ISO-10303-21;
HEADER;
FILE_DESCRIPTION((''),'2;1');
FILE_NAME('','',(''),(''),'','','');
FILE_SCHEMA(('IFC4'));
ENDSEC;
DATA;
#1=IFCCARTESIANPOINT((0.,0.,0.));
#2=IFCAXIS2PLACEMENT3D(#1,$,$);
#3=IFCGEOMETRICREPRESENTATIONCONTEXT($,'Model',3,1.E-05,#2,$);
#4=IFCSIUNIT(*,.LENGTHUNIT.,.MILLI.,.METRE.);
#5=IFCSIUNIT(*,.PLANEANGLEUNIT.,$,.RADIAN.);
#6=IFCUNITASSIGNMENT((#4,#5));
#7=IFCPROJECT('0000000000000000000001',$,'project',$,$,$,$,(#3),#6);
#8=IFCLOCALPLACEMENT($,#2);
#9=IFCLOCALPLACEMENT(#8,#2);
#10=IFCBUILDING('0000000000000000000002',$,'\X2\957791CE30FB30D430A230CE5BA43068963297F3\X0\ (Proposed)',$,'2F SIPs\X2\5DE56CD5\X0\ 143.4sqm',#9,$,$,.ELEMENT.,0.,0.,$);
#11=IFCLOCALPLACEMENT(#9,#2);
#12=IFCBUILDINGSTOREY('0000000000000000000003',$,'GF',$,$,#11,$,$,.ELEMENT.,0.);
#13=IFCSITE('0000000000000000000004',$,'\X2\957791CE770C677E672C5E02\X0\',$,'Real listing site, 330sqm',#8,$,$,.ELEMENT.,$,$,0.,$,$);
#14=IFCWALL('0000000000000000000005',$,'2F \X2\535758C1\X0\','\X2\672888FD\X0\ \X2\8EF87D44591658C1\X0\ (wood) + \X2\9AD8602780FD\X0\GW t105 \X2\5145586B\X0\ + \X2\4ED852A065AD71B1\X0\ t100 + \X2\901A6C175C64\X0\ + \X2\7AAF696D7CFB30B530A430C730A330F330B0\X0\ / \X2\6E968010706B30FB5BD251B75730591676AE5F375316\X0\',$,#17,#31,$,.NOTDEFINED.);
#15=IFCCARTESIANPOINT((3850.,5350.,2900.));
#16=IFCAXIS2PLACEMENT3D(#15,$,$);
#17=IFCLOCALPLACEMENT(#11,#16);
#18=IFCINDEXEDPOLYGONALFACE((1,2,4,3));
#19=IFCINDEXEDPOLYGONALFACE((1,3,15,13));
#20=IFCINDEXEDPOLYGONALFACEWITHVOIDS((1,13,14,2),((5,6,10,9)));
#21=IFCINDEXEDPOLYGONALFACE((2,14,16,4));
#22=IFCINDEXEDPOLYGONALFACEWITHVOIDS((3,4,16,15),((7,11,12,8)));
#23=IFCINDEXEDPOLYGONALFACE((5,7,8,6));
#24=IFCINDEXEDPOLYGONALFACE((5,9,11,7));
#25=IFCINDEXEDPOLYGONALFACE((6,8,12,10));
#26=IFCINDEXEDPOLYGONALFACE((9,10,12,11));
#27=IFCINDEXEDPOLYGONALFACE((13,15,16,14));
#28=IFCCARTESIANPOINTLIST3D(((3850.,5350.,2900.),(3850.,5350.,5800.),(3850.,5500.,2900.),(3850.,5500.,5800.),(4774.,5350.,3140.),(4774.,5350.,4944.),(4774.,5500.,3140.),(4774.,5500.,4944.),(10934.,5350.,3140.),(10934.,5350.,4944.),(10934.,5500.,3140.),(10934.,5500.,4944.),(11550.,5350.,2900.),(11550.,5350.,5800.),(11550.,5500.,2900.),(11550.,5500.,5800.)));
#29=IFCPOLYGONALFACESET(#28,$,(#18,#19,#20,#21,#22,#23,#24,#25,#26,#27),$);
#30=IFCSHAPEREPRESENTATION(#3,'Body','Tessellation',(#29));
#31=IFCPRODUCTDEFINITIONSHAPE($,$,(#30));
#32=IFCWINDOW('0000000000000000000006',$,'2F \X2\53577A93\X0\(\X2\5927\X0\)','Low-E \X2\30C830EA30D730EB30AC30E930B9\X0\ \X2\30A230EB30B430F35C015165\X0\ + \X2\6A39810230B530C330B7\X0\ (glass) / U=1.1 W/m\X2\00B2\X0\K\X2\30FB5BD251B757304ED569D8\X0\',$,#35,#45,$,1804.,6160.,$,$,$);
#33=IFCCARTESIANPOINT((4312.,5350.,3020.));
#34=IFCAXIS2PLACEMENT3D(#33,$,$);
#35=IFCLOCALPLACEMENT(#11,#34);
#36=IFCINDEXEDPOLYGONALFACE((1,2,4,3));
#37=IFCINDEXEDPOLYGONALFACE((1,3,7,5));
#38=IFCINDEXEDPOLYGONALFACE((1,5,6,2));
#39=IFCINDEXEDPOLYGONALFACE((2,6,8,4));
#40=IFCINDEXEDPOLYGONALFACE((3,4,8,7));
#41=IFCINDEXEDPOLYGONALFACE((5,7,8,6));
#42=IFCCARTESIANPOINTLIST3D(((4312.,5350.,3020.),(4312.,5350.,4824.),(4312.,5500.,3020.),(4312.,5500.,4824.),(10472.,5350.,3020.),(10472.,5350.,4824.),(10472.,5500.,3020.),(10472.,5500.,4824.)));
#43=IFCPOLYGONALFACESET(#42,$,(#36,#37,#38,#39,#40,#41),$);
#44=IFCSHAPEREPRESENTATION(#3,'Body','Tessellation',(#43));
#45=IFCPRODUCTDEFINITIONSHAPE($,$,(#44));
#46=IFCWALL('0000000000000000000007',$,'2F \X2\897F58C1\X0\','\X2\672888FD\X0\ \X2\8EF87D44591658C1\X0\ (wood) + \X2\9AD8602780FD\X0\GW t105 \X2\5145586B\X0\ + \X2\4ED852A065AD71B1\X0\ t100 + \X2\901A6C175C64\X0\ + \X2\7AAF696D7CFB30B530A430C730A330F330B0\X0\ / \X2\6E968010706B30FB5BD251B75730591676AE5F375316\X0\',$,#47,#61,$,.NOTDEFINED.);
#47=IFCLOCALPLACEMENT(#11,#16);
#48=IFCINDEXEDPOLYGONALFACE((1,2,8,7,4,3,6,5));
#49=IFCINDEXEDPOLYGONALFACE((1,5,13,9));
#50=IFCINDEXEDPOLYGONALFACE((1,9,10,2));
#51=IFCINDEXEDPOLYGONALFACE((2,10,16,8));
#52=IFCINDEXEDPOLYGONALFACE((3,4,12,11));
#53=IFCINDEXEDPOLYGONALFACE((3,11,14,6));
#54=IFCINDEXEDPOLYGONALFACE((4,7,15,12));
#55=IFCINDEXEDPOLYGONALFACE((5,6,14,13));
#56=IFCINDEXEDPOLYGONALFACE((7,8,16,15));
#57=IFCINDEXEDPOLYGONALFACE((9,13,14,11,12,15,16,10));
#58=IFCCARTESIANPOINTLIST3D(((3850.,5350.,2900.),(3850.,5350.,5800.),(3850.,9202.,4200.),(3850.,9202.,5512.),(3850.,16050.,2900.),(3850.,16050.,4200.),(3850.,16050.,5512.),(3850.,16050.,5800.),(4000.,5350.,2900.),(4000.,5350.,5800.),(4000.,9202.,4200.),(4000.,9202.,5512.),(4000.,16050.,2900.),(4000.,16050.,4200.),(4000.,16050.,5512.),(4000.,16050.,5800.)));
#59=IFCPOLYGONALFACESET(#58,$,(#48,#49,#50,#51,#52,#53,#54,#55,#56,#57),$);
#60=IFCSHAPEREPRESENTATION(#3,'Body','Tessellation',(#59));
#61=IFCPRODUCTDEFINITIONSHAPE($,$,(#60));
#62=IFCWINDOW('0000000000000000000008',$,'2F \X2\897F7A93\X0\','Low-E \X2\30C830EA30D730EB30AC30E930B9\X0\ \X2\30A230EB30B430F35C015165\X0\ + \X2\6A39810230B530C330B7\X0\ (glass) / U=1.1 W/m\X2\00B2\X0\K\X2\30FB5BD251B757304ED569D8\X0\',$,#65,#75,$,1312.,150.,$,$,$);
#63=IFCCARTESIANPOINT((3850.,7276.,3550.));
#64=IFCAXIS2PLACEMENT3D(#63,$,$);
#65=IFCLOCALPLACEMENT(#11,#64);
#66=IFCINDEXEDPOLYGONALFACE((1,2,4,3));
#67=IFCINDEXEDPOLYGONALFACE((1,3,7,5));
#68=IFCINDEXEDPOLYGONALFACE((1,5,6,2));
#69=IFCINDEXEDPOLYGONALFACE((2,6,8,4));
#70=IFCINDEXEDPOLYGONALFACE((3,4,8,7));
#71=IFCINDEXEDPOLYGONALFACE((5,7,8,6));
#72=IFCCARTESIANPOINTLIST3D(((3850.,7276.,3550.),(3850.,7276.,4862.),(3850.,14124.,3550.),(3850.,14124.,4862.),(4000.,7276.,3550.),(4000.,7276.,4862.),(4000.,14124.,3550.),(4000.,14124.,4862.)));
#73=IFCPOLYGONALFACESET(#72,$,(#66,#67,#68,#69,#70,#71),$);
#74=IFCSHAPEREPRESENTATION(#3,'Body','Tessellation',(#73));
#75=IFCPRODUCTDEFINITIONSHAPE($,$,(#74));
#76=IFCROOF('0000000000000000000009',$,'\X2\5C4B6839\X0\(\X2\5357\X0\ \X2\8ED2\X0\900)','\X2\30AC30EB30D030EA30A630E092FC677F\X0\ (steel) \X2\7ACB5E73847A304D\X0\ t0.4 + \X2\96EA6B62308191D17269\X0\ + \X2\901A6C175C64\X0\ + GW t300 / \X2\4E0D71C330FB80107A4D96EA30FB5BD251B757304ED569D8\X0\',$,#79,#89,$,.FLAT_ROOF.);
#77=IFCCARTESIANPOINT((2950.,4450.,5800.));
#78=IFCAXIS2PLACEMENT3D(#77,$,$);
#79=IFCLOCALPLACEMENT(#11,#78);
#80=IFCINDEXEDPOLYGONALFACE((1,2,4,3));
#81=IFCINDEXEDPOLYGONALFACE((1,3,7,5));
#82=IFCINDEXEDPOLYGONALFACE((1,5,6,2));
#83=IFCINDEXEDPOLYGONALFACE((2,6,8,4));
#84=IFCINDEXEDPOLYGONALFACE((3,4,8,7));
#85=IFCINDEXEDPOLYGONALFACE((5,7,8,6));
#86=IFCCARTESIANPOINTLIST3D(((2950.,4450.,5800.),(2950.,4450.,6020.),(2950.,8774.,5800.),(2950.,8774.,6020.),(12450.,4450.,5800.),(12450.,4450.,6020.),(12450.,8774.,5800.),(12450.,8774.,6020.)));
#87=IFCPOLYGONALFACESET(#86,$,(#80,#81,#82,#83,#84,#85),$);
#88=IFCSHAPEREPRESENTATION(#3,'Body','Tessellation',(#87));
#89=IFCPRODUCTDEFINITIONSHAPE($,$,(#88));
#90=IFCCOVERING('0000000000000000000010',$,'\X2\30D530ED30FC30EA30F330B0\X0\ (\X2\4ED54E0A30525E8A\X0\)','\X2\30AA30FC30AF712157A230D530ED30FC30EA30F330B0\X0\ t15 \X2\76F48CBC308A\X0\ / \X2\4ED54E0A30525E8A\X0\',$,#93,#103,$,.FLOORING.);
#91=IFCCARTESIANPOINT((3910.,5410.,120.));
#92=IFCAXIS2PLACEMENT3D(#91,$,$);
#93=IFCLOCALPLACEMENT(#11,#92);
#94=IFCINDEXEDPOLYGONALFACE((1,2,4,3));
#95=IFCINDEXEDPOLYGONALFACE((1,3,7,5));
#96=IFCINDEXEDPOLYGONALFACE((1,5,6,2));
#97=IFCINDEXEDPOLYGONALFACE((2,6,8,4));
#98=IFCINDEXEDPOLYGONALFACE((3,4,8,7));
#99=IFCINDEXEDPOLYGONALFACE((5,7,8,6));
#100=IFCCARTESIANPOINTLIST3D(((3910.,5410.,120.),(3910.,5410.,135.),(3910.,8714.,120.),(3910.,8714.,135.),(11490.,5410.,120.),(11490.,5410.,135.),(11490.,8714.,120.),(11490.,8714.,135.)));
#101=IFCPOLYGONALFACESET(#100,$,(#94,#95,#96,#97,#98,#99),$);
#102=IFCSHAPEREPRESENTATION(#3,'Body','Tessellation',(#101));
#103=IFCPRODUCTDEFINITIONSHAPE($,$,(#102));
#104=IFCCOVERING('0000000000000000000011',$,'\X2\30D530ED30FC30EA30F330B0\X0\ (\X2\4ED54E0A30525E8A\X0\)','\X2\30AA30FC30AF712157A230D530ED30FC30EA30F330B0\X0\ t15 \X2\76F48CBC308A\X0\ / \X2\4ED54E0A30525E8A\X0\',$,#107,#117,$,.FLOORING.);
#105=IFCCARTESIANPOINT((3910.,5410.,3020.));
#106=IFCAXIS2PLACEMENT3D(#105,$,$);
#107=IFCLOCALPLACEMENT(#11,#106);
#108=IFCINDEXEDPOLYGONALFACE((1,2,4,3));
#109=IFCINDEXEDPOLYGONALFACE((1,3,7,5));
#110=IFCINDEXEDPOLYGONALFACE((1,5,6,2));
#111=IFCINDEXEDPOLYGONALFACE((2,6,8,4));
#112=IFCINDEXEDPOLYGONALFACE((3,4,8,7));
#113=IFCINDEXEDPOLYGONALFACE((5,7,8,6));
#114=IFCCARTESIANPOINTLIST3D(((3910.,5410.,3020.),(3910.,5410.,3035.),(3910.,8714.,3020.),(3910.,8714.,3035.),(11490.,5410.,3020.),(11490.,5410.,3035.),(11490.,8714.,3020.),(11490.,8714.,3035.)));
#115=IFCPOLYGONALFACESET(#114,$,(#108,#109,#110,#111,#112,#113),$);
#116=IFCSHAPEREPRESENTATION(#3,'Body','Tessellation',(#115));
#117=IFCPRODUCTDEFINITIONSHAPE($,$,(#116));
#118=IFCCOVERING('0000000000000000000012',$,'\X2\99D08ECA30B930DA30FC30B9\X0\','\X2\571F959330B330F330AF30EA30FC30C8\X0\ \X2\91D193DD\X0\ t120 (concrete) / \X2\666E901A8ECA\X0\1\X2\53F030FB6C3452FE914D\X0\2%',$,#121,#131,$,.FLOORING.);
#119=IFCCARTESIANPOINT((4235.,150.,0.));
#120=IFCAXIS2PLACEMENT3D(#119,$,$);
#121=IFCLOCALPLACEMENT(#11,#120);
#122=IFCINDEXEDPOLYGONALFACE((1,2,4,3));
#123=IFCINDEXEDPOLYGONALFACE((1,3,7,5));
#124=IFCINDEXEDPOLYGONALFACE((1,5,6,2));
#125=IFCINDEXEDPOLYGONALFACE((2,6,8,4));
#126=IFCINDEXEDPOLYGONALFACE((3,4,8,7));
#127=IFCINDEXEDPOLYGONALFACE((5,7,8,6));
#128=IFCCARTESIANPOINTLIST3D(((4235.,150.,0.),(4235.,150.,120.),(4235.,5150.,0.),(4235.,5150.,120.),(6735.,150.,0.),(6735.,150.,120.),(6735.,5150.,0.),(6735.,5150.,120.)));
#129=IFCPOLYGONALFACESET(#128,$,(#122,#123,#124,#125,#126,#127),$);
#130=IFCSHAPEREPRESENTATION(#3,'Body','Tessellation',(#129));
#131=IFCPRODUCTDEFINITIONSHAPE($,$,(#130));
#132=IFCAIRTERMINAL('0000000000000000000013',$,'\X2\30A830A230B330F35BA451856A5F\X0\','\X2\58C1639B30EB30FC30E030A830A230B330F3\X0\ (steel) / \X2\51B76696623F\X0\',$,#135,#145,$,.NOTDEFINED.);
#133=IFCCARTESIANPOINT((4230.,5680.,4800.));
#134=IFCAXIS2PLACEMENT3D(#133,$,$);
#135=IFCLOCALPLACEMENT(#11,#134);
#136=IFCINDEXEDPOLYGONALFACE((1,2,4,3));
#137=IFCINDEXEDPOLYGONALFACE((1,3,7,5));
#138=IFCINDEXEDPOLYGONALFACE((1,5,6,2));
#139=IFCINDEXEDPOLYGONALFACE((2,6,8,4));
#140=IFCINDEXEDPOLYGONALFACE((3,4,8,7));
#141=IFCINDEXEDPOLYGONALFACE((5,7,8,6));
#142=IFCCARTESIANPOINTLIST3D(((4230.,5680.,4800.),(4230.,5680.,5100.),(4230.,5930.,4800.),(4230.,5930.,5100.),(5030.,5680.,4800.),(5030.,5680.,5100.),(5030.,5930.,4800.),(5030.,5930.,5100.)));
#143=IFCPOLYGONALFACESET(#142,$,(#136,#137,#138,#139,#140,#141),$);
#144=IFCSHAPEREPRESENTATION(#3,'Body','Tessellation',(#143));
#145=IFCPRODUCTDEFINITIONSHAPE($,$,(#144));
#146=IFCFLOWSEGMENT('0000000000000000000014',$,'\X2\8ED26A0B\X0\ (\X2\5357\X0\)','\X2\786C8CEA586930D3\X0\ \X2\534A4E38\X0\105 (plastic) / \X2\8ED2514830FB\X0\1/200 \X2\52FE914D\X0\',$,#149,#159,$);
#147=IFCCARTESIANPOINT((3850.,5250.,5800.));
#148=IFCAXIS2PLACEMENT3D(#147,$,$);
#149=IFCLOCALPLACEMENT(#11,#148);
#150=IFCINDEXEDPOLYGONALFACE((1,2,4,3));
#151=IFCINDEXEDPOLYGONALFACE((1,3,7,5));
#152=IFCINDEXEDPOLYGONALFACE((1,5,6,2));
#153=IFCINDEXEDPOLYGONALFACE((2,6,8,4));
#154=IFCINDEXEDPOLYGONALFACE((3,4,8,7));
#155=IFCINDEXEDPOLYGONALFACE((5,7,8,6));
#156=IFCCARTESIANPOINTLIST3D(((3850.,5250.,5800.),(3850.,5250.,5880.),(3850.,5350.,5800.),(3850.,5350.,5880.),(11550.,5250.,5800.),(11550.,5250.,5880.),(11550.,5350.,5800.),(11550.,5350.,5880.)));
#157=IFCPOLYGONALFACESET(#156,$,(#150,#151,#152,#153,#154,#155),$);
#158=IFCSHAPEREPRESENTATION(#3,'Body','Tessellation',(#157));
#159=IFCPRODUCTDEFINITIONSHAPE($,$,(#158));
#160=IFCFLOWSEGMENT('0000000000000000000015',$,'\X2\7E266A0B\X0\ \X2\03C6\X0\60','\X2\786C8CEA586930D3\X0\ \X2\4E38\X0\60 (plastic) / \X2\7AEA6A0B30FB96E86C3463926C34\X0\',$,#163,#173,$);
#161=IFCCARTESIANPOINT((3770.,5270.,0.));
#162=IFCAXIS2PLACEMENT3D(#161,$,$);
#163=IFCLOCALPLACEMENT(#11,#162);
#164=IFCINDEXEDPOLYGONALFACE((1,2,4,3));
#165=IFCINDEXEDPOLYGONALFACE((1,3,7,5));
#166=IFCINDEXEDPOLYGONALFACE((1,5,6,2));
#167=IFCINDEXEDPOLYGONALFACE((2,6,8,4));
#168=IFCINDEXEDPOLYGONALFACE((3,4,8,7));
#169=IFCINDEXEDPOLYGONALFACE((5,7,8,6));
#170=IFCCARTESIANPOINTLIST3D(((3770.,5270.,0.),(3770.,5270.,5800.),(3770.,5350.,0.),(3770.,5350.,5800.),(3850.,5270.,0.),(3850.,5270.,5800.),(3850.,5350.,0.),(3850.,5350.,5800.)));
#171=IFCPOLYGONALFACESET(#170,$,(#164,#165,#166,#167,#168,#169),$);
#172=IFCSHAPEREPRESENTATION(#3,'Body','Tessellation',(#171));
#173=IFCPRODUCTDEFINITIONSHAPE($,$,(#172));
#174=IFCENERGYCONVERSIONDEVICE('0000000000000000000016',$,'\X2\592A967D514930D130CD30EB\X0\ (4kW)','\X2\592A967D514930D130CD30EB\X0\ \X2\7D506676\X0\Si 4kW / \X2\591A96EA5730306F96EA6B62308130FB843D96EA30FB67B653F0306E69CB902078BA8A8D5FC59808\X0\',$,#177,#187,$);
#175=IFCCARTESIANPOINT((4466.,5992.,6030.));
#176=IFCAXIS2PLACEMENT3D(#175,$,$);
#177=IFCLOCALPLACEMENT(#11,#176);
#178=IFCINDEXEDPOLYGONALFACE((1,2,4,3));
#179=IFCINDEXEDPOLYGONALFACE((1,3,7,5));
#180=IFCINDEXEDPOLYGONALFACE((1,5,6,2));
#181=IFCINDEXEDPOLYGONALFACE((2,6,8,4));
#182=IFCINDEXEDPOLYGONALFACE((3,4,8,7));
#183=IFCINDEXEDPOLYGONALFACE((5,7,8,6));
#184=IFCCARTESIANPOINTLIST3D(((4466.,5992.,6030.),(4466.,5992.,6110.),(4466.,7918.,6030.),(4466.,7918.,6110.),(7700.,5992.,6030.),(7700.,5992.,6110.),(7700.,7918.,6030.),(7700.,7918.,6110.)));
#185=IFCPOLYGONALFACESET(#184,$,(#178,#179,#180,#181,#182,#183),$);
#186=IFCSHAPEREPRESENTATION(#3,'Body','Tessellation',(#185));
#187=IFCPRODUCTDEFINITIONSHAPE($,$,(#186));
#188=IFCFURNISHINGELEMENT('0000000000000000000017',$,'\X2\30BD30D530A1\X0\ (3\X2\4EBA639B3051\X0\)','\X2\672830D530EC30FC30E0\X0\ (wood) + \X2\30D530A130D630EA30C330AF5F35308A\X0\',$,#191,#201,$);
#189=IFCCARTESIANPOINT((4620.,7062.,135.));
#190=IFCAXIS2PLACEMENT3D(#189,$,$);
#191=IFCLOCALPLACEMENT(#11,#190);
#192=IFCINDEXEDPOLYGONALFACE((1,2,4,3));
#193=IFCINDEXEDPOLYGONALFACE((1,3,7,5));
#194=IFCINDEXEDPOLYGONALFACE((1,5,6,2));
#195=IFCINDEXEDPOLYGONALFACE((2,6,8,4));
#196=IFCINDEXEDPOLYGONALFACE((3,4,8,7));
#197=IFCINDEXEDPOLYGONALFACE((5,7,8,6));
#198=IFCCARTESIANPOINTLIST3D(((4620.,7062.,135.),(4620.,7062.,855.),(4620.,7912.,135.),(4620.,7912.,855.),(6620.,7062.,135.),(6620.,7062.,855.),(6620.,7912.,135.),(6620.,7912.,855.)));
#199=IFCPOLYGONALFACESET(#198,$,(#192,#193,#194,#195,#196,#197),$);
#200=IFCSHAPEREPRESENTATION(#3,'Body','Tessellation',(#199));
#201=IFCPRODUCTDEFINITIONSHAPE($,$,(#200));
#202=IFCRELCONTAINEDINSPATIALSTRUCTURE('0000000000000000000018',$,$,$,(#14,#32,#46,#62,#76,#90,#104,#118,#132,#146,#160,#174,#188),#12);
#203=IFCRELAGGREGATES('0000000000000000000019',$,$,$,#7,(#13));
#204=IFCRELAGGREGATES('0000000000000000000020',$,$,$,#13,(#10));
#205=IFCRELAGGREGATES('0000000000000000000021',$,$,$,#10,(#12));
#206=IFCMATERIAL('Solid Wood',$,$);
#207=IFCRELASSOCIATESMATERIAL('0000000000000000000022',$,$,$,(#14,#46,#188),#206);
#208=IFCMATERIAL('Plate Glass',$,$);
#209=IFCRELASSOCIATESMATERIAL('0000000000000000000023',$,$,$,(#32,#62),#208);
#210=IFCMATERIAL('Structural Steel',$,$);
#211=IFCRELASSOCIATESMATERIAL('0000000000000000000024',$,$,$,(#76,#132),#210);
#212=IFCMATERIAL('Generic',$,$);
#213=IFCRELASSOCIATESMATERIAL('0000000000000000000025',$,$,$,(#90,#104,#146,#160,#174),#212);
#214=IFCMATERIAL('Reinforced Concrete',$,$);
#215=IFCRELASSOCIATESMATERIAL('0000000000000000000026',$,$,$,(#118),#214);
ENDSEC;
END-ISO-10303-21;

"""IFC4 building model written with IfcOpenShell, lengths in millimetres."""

from ifc_helpers import new_model, si_unit, frame, frame_2d, origin, place, context, project, spatial, rectangle, extrude, material, element, fill, save


model = new_model("IFC4")

# Units and contexts
model_context = context("Model", 3, precision=1e-05, world=origin())
ifc_project = project(units=[si_unit("LENGTHUNIT", "METRE", prefix="MILLI"), si_unit("PLANEANGLEUNIT", "RADIAN")], contexts=[model_context])

# Site, building, storey
site_placement = place(None, origin())
site = spatial("IfcSite", under=ifc_project, at=site_placement, Name="長野県松本市", ObjectType="Real listing site, 330sqm", CompositionType="ELEMENT", RefElevation=0.0)
building_placement = place(site_placement, origin())
building = spatial("IfcBuilding", under=site, at=building_placement, Name="長野・ピアノ室と防音 (Proposed)", ObjectType="2F SIPs工法 143.4sqm", CompositionType="ELEMENT", ElevationOfRefHeight=0.0, ElevationOfTerrain=0.0)
storey_placement = place(building_placement, origin())
storey = spatial("IfcBuildingStorey", under=building, at=storey_placement, Name="GF", CompositionType="ELEMENT", Elevation=0.0)

# Shared definitions
ifc_material_1 = material(Name="Solid Wood")

# Shared definitions
ifc_material_2 = material(Name="Reinforced Concrete")

# Shared definitions
ifc_material_3 = material(Name="Plate Glass")

# Walls, openings, windows
wall_1_placement = place(storey_placement, frame((3850.0, 5350.0, 2900.0)))
wall_1 = element("IfcWall", 1, at=wall_1_placement, inside=storey, material=ifc_material_1, Name="2F 南壁", Description="木製 軸組外壁 (wood) + 高性能GW t105 充填 + 付加断熱 t100 + 通気層 + 窯業系サイディング / 準耐火・寒冷地外皮強化", PredefinedType="NOTDEFINED", context=model_context, shape_type="SweptSolid", body=[
    extrude(rectangle(XDim=7700.0, YDim=150.0, at=frame_2d((3850.0, 75.0))), frame((3850.0, 5350.0, 2900.0)), (0.0, 0.0, 1.0), 2900.0),
])
opening_1_placement = place(storey_placement, frame((4312.0, 5350.0, 3020.0)))
opening_1 = element("IfcOpeningElement", 2, at=opening_1_placement, cuts=wall_1, PredefinedType="NOTDEFINED", context=model_context, shape_type="SweptSolid", body=[
    extrude(rectangle(XDim=6160.0, YDim=150.0, at=frame_2d((3080.0, 75.0))), frame((4312.0, 5350.0, 3020.0)), (0.0, 0.0, 1.0), 1804.0),
])
window_1_placement = place(storey_placement, frame((4312.0, 5350.0, 3020.0)))
window_1 = element("IfcWindow", 3, at=window_1_placement, inside=storey, material=ifc_material_3, Name="2F 南窓(大)", Description="Low-E トリプルガラス アルゴン封入 + 樹脂サッシ (glass) / U=1.1 W/m²K・寒冷地仕様", OverallHeight=1804.0, OverallWidth=6160.0, context=model_context, shape_type="SweptSolid", body=[
    extrude(rectangle(XDim=6160.0, YDim=150.0, at=frame_2d((3080.0, 75.0))), frame((4312.0, 5350.0, 3020.0)), (0.0, 0.0, 1.0), 1804.0),
])
fill(opening_1, window_1)
wall_2_placement = place(storey_placement, frame((3850.0, 5350.0, 2900.0)))
wall_2 = element("IfcWall", 4, at=wall_2_placement, inside=storey, material=ifc_material_1, Name="2F 西壁", Description="木製 軸組外壁 (wood) + 高性能GW t105 充填 + 付加断熱 t100 + 通気層 + 窯業系サイディング / 準耐火・寒冷地外皮強化", PredefinedType="NOTDEFINED", context=model_context, shape_type="SweptSolid", body=[
    extrude(rectangle(XDim=150.0, YDim=10700.0, at=frame_2d((75.0, 5350.0))), frame((3850.0, 5350.0, 2900.0)), (0.0, 0.0, 1.0), 2900.0),
])
opening_2_placement = place(storey_placement, frame((3850.0, 7276.0, 3550.0)))
opening_2 = element("IfcOpeningElement", 5, at=opening_2_placement, cuts=wall_2, PredefinedType="NOTDEFINED", context=model_context, shape_type="SweptSolid", body=[
    extrude(rectangle(XDim=150.0, YDim=6848.0, at=frame_2d((75.0, 3424.0))), frame((3850.0, 7276.0, 3550.0)), (0.0, 0.0, 1.0), 1312.0),
])
window_2_placement = place(storey_placement, frame((3850.0, 7276.0, 3550.0)))
window_2 = element("IfcWindow", 6, at=window_2_placement, inside=storey, material=ifc_material_3, Name="2F 西窓", Description="Low-E トリプルガラス アルゴン封入 + 樹脂サッシ (glass) / U=1.1 W/m²K・寒冷地仕様", OverallHeight=1312.0, OverallWidth=150.0, context=model_context, shape_type="SweptSolid", body=[
    extrude(rectangle(XDim=150.0, YDim=6848.0, at=frame_2d((75.0, 3424.0))), frame((3850.0, 7276.0, 3550.0)), (0.0, 0.0, 1.0), 1312.0),
])
fill(opening_2, window_2)

# Roof
ifc_material_4 = material(Name="Structural Steel")
for number, where, name in (
    (7, (2950.0, 4450.0, 5800.0), "屋根(南 軒900)"),
):
    element("IfcRoof", number, at=place(storey_placement, frame(where)), inside=storey, material=ifc_material_4, Name=name, Description="ガルバリウム鋼板 (steel) 立平葺き t0.4 + 雪止め金物 + 通気層 + GW t300 / 不燃・耐積雪・寒冷地仕様", PredefinedType="FLAT_ROOF", context=model_context, shape_type="SweptSolid", body=[
        extrude(rectangle(XDim=9500.0, YDim=4324.0, at=frame_2d((4750.0, 2162.0))), frame((2950.0, 4450.0, 5800.0)), (0.0, 0.0, 1.0), 220.0),
    ])

# Coverings
ifc_material_5 = material(Name="Generic")
covering_1_placement = place(storey_placement, frame((3910.0, 5410.0, 120.0)))
element("IfcCovering", 8, at=covering_1_placement, inside=storey, material=ifc_material_5, Name="フローリング (仕上げ床)", Description="オーク無垢フローリング t15 直貼り / 仕上げ床", PredefinedType="FLOORING", context=model_context, shape_type="SweptSolid", body=[
    extrude(rectangle(XDim=7580.0, YDim=3304.0, at=frame_2d((3790.0, 1652.0))), frame((3910.0, 5410.0, 120.0)), (0.0, 0.0, 1.0), 15.0),
])
covering_2_placement = place(storey_placement, frame((3910.0, 5410.0, 3020.0)))
element("IfcCovering", 9, at=covering_2_placement, inside=storey, material=ifc_material_5, Name="フローリング (仕上げ床)", Description="オーク無垢フローリング t15 直貼り / 仕上げ床", PredefinedType="FLOORING", context=model_context, shape_type="SweptSolid", body=[
    extrude(rectangle(XDim=7580.0, YDim=3304.0, at=frame_2d((3790.0, 1652.0))), frame((3910.0, 5410.0, 3020.0)), (0.0, 0.0, 1.0), 15.0),
])
covering_3_placement = place(storey_placement, frame((4235.0, 150.0, 0.0)))
element("IfcCovering", 10, at=covering_3_placement, inside=storey, material=ifc_material_2, Name="駐車スペース", Description="土間コンクリート 金鏝 t120 (concrete) / 普通車1台・水勾配2%", PredefinedType="FLOORING", context=model_context, shape_type="SweptSolid", body=[
    extrude(rectangle(XDim=2500.0, YDim=5000.0, at=frame_2d((1250.0, 2500.0))), frame((4235.0, 150.0, 0.0)), (0.0, 0.0, 1.0), 120.0),
])

# Air terminal
air_terminal_placement = place(storey_placement, frame((4230.0, 5680.0, 4800.0)))
element("IfcAirTerminal", 11, at=air_terminal_placement, inside=storey, material=ifc_material_4, Name="エアコン室内機", Description="壁掛ルームエアコン (steel) / 冷暖房", PredefinedType="NOTDEFINED", context=model_context, shape_type="SweptSolid", body=[
    extrude(rectangle(XDim=800.0, YDim=250.0, at=frame_2d((400.0, 125.0))), frame((4230.0, 5680.0, 4800.0)), (0.0, 0.0, 1.0), 300.0),
])

# Flow segments
flow_segment_1_placement = place(storey_placement, frame((3850.0, 5250.0, 5800.0)))
element("IfcFlowSegment", 12, at=flow_segment_1_placement, inside=storey, material=ifc_material_5, Name="軒樋 (南)", Description="硬質塩ビ 半丸105 (plastic) / 軒先・1/200 勾配", context=model_context, shape_type="SweptSolid", body=[
    extrude(rectangle(XDim=7700.0, YDim=100.0, at=frame_2d((3850.0, 50.0))), frame((3850.0, 5250.0, 5800.0)), (0.0, 0.0, 1.0), 80.0),
])
flow_segment_2_placement = place(storey_placement, frame((3770.0, 5270.0, 0.0)))
element("IfcFlowSegment", 13, at=flow_segment_2_placement, inside=storey, material=ifc_material_5, Name="縦樋 φ60", Description="硬質塩ビ 丸60 (plastic) / 竪樋・雨水排水", context=model_context, shape_type="SweptSolid", body=[
    extrude(rectangle(XDim=80.0, YDim=80.0, at=frame_2d((40.0, 40.0))), frame((3770.0, 5270.0, 0.0)), (0.0, 0.0, 1.0), 5800.0),
])

# Energy conversion device
energy_conversion_device_placement = place(storey_placement, frame((4466.0, 5992.0, 6030.0)))
element("IfcEnergyConversionDevice", 14, at=energy_conversion_device_placement, inside=storey, material=ifc_material_5, Name="太陽光パネル (4kW)", Description="太陽光パネル 結晶Si 4kW / 多雪地は雪止め・落雪・架台の構造確認必須", context=model_context, shape_type="SweptSolid", body=[
    extrude(rectangle(XDim=3234.0, YDim=1926.0, at=frame_2d((1617.0, 963.0))), frame((4466.0, 5992.0, 6030.0)), (0.0, 0.0, 1.0), 80.0),
])

# Furnishing element
furnishing_1_placement = place(storey_placement, frame((4620.0, 7062.0, 135.0)))
element("IfcFurnishingElement", 15, at=furnishing_1_placement, inside=storey, material=ifc_material_1, Name="ソファ (3人掛け)", Description="木フレーム (wood) + ファブリック張り", context=model_context, shape_type="SweptSolid", body=[
    extrude(rectangle(XDim=2000.0, YDim=850.0, at=frame_2d((1000.0, 425.0))), frame((4620.0, 7062.0, 135.0)), (0.0, 0.0, 1.0), 720.0),
])

save(model, "model.ifc")
